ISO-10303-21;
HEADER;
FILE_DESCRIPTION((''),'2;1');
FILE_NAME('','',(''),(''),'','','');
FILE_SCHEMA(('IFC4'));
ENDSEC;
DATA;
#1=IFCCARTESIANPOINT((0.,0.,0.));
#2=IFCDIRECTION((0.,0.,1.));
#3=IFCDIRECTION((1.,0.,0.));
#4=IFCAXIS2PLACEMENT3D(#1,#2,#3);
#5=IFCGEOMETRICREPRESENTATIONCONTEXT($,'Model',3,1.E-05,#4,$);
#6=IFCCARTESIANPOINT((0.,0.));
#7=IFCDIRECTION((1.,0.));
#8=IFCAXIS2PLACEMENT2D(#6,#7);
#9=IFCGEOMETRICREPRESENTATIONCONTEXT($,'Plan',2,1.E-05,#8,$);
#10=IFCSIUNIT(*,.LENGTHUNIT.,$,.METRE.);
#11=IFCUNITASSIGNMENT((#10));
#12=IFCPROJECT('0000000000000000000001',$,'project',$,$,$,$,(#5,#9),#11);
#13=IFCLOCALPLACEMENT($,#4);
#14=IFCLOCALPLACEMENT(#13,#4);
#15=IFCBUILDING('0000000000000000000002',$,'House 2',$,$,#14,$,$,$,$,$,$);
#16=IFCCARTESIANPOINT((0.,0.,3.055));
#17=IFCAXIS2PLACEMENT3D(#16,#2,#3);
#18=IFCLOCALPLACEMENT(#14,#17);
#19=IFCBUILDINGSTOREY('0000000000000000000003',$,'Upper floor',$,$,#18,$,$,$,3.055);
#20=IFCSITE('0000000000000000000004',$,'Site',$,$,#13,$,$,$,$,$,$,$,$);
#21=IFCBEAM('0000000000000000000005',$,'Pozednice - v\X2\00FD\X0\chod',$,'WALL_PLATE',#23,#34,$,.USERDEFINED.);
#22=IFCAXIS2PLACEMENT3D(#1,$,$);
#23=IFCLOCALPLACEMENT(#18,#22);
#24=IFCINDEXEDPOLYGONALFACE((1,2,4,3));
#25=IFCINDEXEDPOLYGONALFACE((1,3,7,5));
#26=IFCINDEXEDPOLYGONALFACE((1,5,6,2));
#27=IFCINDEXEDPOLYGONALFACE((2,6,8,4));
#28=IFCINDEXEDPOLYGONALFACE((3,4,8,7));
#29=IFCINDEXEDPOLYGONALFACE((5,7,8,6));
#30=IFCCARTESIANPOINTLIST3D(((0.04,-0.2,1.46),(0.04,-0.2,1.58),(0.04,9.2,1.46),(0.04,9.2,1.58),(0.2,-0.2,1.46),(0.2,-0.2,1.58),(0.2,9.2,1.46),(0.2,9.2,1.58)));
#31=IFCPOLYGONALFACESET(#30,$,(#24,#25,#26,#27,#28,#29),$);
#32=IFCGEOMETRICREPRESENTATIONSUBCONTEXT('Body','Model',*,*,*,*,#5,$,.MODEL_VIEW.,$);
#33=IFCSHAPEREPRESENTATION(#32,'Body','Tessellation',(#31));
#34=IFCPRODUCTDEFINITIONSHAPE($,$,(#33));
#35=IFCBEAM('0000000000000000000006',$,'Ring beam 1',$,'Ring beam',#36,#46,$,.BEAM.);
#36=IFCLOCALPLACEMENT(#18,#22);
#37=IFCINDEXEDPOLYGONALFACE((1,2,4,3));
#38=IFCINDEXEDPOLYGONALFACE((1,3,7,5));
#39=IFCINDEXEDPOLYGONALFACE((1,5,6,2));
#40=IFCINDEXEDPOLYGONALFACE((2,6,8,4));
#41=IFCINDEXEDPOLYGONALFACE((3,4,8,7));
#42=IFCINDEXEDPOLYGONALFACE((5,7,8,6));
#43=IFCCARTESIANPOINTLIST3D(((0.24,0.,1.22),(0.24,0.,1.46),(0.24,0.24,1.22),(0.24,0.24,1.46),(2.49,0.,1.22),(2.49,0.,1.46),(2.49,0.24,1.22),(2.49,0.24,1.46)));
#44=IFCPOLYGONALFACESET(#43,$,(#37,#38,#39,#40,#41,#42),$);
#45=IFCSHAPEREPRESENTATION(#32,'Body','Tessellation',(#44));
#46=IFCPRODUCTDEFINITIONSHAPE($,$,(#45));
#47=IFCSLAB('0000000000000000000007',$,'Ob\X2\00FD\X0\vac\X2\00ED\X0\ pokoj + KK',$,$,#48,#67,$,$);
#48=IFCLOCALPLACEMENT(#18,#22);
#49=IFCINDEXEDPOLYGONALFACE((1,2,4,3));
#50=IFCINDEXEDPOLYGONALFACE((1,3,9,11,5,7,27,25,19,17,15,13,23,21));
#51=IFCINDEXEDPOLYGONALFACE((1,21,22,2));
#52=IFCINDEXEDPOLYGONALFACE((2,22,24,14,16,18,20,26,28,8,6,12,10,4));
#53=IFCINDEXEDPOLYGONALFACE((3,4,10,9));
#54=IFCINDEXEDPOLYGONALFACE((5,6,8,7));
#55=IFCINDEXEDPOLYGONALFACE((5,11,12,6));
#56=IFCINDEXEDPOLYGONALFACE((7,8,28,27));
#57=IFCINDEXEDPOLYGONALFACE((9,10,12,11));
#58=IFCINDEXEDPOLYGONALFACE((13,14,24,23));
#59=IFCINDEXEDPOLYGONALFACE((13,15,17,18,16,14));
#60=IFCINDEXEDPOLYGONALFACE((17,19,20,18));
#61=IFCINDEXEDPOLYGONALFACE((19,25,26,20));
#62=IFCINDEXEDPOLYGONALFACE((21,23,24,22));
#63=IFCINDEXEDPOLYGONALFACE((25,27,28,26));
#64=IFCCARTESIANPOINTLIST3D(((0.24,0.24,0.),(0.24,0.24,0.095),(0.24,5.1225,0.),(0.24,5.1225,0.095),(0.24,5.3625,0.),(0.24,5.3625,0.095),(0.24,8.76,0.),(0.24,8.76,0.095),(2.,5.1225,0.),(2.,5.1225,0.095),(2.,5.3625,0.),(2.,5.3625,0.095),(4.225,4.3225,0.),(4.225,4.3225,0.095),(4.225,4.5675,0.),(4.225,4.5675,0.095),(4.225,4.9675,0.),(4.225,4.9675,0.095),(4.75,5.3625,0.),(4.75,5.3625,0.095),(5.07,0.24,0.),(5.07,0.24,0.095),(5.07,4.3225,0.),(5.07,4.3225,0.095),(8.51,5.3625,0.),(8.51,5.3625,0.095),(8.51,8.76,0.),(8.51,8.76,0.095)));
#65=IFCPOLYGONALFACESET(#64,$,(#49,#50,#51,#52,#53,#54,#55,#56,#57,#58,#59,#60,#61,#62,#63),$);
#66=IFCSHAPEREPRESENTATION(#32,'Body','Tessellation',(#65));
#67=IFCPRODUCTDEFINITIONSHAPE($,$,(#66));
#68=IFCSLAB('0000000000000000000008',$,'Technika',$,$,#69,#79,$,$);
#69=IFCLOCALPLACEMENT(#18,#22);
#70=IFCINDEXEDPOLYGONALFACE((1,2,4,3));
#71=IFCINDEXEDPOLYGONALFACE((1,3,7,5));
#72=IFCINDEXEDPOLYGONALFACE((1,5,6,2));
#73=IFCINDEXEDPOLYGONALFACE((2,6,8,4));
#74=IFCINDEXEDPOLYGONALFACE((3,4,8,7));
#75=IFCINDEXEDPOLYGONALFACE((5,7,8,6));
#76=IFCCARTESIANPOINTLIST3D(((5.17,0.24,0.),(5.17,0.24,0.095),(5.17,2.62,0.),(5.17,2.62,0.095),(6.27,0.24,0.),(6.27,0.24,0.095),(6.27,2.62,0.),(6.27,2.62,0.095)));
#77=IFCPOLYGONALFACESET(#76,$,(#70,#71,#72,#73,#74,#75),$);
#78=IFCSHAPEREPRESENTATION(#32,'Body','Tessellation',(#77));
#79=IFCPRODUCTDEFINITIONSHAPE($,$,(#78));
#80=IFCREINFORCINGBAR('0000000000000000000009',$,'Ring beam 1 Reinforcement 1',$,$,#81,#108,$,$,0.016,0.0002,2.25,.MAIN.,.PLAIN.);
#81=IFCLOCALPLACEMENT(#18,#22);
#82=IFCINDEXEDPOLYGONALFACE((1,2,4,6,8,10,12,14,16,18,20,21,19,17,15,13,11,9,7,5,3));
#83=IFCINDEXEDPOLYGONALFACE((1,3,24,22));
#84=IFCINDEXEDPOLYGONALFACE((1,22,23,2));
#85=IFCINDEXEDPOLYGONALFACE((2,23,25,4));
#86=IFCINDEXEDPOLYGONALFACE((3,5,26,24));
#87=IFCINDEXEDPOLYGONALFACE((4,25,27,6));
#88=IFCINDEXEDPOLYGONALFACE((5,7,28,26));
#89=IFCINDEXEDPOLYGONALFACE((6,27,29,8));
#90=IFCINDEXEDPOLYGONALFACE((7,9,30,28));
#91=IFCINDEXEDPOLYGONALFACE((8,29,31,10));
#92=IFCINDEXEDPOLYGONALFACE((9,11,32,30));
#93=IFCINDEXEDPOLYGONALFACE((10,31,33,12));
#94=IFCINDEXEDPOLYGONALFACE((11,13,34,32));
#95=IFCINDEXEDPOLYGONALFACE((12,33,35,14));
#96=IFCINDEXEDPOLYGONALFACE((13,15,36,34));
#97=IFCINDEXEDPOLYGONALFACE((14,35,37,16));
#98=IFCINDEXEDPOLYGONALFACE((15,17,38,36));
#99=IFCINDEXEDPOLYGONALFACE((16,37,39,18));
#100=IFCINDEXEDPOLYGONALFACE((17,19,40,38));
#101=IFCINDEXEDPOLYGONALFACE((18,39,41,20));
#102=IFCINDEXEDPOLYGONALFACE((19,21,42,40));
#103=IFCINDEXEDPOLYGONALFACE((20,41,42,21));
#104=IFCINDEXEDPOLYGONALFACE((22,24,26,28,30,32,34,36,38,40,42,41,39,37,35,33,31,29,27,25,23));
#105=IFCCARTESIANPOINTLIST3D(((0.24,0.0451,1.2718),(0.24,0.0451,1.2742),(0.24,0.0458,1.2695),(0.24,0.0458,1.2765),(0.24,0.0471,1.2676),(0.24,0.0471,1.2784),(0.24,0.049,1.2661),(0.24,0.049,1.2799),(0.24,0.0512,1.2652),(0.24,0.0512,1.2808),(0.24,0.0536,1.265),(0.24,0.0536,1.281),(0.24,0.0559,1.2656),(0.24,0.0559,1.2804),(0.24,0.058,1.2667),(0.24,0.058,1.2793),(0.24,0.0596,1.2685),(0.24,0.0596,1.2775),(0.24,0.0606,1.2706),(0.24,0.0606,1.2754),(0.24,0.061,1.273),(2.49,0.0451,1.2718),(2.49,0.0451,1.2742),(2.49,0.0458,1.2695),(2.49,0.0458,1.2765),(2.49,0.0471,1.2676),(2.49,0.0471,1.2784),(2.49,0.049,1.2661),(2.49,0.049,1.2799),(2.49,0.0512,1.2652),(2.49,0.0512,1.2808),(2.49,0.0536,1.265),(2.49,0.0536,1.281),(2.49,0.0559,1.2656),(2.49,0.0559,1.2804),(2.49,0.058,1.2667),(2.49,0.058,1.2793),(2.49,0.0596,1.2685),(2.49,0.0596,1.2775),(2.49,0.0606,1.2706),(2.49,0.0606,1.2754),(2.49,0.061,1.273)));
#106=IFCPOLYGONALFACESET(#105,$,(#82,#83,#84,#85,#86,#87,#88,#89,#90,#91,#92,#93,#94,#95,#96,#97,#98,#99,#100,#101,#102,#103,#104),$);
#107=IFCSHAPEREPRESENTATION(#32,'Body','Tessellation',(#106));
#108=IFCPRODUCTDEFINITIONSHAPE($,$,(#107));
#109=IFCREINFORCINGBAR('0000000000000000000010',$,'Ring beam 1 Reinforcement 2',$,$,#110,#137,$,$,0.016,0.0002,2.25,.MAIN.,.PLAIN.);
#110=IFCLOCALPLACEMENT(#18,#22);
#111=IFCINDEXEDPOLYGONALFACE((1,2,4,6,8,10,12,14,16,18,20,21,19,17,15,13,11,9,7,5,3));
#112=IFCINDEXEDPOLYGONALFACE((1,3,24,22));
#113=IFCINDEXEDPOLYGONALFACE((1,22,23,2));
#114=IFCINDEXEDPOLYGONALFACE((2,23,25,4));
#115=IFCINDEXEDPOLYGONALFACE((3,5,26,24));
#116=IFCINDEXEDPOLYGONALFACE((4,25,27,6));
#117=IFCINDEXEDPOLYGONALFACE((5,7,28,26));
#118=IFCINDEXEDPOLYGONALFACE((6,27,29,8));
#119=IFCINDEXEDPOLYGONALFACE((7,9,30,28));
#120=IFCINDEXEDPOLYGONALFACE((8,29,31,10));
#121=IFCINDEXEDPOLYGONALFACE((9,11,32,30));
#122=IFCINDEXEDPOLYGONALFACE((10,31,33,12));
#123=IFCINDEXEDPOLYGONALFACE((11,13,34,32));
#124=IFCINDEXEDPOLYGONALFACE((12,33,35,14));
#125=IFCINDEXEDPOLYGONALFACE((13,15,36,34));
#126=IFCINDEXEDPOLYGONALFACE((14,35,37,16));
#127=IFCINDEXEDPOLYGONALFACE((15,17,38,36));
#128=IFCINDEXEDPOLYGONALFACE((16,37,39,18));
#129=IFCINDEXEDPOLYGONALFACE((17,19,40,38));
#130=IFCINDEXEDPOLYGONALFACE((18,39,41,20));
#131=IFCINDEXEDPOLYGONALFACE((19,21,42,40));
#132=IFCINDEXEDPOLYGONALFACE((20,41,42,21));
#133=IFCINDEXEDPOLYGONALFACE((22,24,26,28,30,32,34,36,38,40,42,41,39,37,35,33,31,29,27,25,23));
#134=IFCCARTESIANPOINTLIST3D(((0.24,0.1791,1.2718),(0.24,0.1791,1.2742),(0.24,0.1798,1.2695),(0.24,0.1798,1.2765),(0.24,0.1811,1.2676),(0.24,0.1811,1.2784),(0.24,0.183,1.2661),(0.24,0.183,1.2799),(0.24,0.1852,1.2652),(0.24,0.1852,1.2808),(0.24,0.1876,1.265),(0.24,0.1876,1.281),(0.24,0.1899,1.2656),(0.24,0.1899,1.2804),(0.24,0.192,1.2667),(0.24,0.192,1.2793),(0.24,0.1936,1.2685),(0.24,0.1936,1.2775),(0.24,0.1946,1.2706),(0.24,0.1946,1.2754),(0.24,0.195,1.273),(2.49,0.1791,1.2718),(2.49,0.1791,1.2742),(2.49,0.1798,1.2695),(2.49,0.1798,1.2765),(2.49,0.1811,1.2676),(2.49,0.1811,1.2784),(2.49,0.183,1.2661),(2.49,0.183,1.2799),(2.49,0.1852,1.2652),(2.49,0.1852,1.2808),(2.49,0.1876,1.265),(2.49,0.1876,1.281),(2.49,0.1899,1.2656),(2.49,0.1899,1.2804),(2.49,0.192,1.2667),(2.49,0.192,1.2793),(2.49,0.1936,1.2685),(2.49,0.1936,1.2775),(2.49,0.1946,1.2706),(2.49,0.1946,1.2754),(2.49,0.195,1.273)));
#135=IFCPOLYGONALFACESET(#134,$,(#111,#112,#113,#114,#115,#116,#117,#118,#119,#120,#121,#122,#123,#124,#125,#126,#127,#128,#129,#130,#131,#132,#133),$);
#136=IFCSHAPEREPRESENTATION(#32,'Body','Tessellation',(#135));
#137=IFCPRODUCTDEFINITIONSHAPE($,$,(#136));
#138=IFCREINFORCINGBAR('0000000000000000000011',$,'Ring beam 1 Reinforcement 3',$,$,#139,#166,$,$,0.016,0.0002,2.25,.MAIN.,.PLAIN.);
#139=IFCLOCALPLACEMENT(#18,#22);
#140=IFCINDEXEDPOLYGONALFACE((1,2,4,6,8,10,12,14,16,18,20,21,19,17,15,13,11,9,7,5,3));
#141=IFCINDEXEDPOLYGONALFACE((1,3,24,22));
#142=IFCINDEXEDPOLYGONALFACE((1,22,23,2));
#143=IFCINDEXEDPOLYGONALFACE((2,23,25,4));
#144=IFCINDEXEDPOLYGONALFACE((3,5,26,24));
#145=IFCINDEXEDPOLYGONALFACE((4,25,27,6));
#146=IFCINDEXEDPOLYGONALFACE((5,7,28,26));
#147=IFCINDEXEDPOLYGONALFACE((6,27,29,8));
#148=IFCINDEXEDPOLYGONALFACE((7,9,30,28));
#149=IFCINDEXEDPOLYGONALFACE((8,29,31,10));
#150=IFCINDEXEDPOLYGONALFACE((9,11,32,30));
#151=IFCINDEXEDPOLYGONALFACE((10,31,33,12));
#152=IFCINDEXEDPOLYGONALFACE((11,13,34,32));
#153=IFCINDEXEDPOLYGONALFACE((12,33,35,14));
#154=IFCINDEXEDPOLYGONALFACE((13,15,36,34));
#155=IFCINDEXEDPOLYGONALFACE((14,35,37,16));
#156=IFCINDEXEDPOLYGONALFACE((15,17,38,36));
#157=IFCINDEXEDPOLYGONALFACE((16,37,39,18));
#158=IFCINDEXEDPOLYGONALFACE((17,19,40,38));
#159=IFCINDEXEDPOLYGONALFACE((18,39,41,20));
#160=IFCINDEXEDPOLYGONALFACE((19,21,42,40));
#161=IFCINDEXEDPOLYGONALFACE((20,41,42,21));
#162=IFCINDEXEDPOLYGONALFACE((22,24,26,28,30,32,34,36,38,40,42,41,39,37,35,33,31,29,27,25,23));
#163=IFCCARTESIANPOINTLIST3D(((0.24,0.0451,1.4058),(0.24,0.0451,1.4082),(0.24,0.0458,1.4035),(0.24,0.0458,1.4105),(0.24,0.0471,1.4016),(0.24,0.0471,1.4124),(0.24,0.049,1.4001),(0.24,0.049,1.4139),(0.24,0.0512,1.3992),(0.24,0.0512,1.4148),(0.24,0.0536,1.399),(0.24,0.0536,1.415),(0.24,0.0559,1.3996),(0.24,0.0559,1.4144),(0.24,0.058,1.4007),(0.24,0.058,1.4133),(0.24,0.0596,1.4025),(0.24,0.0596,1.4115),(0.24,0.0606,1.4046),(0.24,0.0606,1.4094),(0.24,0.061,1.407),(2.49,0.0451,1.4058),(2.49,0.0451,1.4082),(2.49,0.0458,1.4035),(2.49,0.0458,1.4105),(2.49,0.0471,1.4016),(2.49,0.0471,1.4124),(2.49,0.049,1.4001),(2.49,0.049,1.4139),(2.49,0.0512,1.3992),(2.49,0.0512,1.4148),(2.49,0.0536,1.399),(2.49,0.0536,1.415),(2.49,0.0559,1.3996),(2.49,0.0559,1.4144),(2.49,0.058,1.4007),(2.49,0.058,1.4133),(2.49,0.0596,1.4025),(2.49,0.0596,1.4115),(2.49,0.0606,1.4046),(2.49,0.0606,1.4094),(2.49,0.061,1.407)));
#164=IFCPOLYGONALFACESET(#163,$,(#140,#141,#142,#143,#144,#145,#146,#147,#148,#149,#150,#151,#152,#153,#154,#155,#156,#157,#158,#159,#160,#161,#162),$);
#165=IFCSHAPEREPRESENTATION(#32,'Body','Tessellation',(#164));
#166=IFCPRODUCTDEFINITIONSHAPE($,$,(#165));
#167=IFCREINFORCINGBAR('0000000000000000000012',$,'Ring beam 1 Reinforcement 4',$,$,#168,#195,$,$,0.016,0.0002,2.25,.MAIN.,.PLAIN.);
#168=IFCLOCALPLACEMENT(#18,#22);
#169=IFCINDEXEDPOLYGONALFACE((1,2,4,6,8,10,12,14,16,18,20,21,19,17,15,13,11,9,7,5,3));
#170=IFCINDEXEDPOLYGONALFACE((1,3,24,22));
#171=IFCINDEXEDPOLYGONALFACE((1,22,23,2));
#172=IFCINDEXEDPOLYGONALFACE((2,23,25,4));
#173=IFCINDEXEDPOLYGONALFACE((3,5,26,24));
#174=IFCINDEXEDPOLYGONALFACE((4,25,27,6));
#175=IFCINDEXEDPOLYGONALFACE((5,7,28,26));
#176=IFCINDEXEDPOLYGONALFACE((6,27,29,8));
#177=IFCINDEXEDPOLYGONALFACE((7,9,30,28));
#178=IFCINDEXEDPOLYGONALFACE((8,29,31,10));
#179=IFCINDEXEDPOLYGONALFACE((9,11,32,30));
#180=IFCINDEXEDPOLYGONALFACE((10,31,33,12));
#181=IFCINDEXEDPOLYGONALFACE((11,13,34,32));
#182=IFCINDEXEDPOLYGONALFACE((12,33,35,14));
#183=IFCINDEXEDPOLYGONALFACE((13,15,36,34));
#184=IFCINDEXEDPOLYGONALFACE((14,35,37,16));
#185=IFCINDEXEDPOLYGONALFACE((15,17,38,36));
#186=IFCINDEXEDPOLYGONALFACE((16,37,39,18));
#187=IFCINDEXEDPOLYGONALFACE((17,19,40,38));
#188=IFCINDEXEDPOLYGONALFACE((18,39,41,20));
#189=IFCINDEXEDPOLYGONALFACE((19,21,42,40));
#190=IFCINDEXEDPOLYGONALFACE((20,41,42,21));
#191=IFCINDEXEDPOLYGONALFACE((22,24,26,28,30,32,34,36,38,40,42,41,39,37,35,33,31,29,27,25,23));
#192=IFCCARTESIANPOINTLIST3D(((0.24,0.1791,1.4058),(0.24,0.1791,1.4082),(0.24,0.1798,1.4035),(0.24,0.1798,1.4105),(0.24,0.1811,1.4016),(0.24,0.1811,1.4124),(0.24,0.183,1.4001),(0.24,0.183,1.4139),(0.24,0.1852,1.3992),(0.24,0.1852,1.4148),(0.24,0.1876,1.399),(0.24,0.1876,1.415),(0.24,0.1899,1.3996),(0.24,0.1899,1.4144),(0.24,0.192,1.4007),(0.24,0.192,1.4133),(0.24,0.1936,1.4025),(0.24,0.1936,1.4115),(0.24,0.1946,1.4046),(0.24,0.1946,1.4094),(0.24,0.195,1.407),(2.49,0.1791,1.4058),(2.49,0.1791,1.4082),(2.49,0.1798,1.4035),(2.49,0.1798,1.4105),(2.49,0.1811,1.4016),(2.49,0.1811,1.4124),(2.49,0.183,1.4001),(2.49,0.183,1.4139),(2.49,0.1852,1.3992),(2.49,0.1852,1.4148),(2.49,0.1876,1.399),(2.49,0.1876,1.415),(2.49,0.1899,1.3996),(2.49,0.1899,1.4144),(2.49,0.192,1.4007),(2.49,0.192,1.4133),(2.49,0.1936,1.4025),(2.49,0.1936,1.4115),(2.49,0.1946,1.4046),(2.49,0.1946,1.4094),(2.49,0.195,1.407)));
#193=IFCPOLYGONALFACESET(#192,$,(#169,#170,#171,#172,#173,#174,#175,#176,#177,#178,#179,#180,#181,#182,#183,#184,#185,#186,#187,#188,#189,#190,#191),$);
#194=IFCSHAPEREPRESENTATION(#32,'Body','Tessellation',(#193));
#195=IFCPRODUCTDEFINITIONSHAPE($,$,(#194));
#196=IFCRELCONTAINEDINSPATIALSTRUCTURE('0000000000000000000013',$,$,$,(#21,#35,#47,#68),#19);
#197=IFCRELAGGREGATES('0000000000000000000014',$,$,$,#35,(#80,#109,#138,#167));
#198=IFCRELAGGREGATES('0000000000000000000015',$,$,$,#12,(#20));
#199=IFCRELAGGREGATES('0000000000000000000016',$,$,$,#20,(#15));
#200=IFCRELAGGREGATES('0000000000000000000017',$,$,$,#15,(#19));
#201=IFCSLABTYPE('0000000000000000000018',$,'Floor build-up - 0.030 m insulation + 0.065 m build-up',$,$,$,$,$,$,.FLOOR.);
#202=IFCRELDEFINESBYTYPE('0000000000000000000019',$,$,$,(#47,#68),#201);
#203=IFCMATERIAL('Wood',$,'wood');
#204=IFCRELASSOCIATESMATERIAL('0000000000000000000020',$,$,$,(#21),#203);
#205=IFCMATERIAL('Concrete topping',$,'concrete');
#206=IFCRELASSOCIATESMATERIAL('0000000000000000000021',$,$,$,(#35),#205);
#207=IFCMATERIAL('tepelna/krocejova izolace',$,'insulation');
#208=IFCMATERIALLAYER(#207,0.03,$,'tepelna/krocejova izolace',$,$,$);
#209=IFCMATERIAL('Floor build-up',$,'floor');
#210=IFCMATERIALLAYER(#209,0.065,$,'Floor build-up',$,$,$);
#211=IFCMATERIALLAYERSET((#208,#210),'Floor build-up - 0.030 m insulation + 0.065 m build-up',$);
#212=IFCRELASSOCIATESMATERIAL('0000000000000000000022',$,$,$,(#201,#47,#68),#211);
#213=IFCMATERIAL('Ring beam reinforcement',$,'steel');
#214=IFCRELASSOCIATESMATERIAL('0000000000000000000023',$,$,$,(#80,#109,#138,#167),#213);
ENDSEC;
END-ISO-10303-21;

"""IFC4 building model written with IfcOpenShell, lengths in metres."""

from ifc_helpers import new_model, si_unit, frame, origin_with_axes, origin_2d, origin_2d_with_axis, place, context, subcontext, project, spatial, indexed_curve, circle_curve, rectangle, outline, extrude, material, layer, layer_set, layer_usage, type_object, element, aggregate, save


model = new_model("IFC4")

# Units and contexts
model_context = context("Model", 3, precision=1e-05, world=origin_with_axes())
plan_context = context("Plan", 2, precision=1e-05, world=origin_2d_with_axis())
body_context_1 = subcontext(model_context, "Body", "Model", "MODEL_VIEW")
ifc_project = project(units=[si_unit("LENGTHUNIT", "METRE")], contexts=[model_context, plan_context])

# Site, building, storey
site_placement = place(None, origin_with_axes())
site = spatial("IfcSite", under=ifc_project, at=site_placement, Name="Site")
building_placement = place(site_placement, origin_with_axes())
building = spatial("IfcBuilding", under=site, at=building_placement, Name="House 2")
storey_placement = place(building_placement, frame((0.0, 0.0, 3.055), z_axis=(0.0, 0.0, 1.0), x_axis=(1.0, 0.0, 0.0)))
storey = spatial("IfcBuildingStorey", under=building, at=storey_placement, Name="Upper floor", Elevation=3.055)

# Beam
ifc_material_1 = material(Name="Wood", Category="wood")
beam_1_placement = place(storey_placement, frame((0.12, -0.2, 1.52), z_axis=(0.0, 0.0, 1.0), x_axis=(0.0, 1.0, 0.0)))
element("IfcBeam", 1, at=beam_1_placement, inside=storey, material=ifc_material_1, Name="Pozednice - východ", ObjectType="WALL_PLATE", PredefinedType="USERDEFINED", context=body_context_1, shape_type="SweptSolid", body=[
    extrude(rectangle(XDim=0.16, YDim=0.12), frame((0.0, 0.0, 0.0), z_axis=(1.0, 0.0, 0.0), x_axis=(0.0, 1.0, 0.0)), (0.0, 0.0, 1.0), 9.4),
])

# Beam
ifc_material_2 = material(Name="Concrete topping", Category="concrete")
beam_2_placement = place(storey_placement, frame((0.24, 0.12, 1.34), z_axis=(0.0, 0.0, 1.0), x_axis=(1.0, 0.0, 0.0)))
beam_2 = element("IfcBeam", 2, at=beam_2_placement, inside=storey, material=ifc_material_2, Name="Ring beam 1", ObjectType="Ring beam", PredefinedType="BEAM", context=body_context_1, shape_type="SweptSolid", body=[
    extrude(rectangle(XDim=0.24, YDim=0.24), frame((0.0, 0.0, 0.0), z_axis=(1.0, 0.0, 0.0), x_axis=(0.0, 1.0, 0.0)), (0.0, 0.0, 1.0), 2.25),
])

# Slabs
ifc_material_3 = material(Name="tepelna/krocejova izolace", Category="insulation")
ifc_layer_1 = layer(ifc_material_3, 0.03, Name="tepelna/krocejova izolace")
ifc_material_4 = material(Name="Floor build-up", Category="floor")
ifc_layer_2 = layer(ifc_material_4, 0.065, Name="Floor build-up")
ifc_layer_set_1 = layer_set([ifc_layer_1, ifc_layer_2], Name="Floor build-up - 0.030 m insulation + 0.065 m build-up")
ifc_layer_usage_1 = layer_usage(ifc_layer_set_1, "AXIS3", "POSITIVE", 0.0)
slab_type = type_object("IfcSlabType", Name="Floor build-up - 0.030 m insulation + 0.065 m build-up", PredefinedType="FLOOR", material=ifc_layer_set_1)
slab_1_placement = place(storey_placement, origin_with_axes())
element("IfcSlab", 3, at=slab_1_placement, inside=storey, type_object=slab_type, material=ifc_layer_usage_1, Name="Obývací pokoj + KK", context=body_context_1, shape_type="SweptSolid", body=[
    extrude(outline(indexed_curve([(4.225, 4.5675), (4.225, 4.3225), (5.07, 4.3225), (5.07, 0.24), (0.24, 0.24), (0.24, 5.1225), (2.0, 5.1225), (2.0, 5.3625), (0.24, 5.3625), (0.24, 8.76), (8.51, 8.76), (8.51, 5.3625), (4.75, 5.3625), (4.225, 4.9675)])), None, (0.0, 0.0, 1.0), 0.095),
])
ifc_layer_usage_2 = layer_usage(ifc_layer_set_1, "AXIS3", "POSITIVE", 0.0)
slab_2_placement = place(storey_placement, origin_with_axes())
element("IfcSlab", 4, at=slab_2_placement, inside=storey, type_object=slab_type, material=ifc_layer_usage_2, Name="Technika", context=body_context_1, shape_type="SweptSolid", body=[
    extrude(outline(indexed_curve([(6.27, 0.24), (6.27, 2.62), (5.17, 2.62), (5.17, 0.24)])), None, (0.0, 0.0, 1.0), 0.095),
])

# Reinforcing bars
ifc_material_5 = material(Name="Ring beam reinforcement", Category="steel")
reinforcing_bar_1_placement = place(beam_2_placement, frame((0.0, -0.067, -0.067), z_axis=(0.0, 0.0, 1.0), x_axis=(1.0, 0.0, 0.0)))
reinforcing_bar_1 = element("IfcReinforcingBar", 5, at=reinforcing_bar_1_placement, material=ifc_material_5, Name="Ring beam 1 Reinforcement 1", BarLength=2.25, BarSurface="PLAIN", CrossSectionArea=0.0002, NominalDiameter=0.016, PredefinedType="MAIN", context=body_context_1, shape_type="SweptSolid", body=[
    extrude(outline(circle_curve(origin_2d(), 0.008)), frame((0.0, 0.0, 0.0), z_axis=(1.0, 0.0, 0.0), x_axis=(0.0, 1.0, 0.0)), (0.0, 0.0, 1.0), 2.25),
])
reinforcing_bar_2_placement = place(beam_2_placement, frame((0.0, 0.067, -0.067), z_axis=(0.0, 0.0, 1.0), x_axis=(1.0, 0.0, 0.0)))
reinforcing_bar_2 = element("IfcReinforcingBar", 6, at=reinforcing_bar_2_placement, material=ifc_material_5, Name="Ring beam 1 Reinforcement 2", BarLength=2.25, BarSurface="PLAIN", CrossSectionArea=0.0002, NominalDiameter=0.016, PredefinedType="MAIN", context=body_context_1, shape_type="SweptSolid", body=[
    extrude(outline(circle_curve(origin_2d(), 0.008)), frame((0.0, 0.0, 0.0), z_axis=(1.0, 0.0, 0.0), x_axis=(0.0, 1.0, 0.0)), (0.0, 0.0, 1.0), 2.25),
])
reinforcing_bar_3_placement = place(beam_2_placement, frame((0.0, -0.067, 0.067), z_axis=(0.0, 0.0, 1.0), x_axis=(1.0, 0.0, 0.0)))
reinforcing_bar_3 = element("IfcReinforcingBar", 7, at=reinforcing_bar_3_placement, material=ifc_material_5, Name="Ring beam 1 Reinforcement 3", BarLength=2.25, BarSurface="PLAIN", CrossSectionArea=0.0002, NominalDiameter=0.016, PredefinedType="MAIN", context=body_context_1, shape_type="SweptSolid", body=[
    extrude(outline(circle_curve(origin_2d(), 0.008)), frame((0.0, 0.0, 0.0), z_axis=(1.0, 0.0, 0.0), x_axis=(0.0, 1.0, 0.0)), (0.0, 0.0, 1.0), 2.25),
])
reinforcing_bar_4_placement = place(beam_2_placement, frame((0.0, 0.067, 0.067), z_axis=(0.0, 0.0, 1.0), x_axis=(1.0, 0.0, 0.0)))
reinforcing_bar_4 = element("IfcReinforcingBar", 8, at=reinforcing_bar_4_placement, material=ifc_material_5, Name="Ring beam 1 Reinforcement 4", BarLength=2.25, BarSurface="PLAIN", CrossSectionArea=0.0002, NominalDiameter=0.016, PredefinedType="MAIN", context=body_context_1, shape_type="SweptSolid", body=[
    extrude(outline(circle_curve(origin_2d(), 0.008)), frame((0.0, 0.0, 0.0), z_axis=(1.0, 0.0, 0.0), x_axis=(0.0, 1.0, 0.0)), (0.0, 0.0, 1.0), 2.25),
])
aggregate(beam_2, [reinforcing_bar_1, reinforcing_bar_2, reinforcing_bar_3, reinforcing_bar_4])

save(model, "model.ifc")
